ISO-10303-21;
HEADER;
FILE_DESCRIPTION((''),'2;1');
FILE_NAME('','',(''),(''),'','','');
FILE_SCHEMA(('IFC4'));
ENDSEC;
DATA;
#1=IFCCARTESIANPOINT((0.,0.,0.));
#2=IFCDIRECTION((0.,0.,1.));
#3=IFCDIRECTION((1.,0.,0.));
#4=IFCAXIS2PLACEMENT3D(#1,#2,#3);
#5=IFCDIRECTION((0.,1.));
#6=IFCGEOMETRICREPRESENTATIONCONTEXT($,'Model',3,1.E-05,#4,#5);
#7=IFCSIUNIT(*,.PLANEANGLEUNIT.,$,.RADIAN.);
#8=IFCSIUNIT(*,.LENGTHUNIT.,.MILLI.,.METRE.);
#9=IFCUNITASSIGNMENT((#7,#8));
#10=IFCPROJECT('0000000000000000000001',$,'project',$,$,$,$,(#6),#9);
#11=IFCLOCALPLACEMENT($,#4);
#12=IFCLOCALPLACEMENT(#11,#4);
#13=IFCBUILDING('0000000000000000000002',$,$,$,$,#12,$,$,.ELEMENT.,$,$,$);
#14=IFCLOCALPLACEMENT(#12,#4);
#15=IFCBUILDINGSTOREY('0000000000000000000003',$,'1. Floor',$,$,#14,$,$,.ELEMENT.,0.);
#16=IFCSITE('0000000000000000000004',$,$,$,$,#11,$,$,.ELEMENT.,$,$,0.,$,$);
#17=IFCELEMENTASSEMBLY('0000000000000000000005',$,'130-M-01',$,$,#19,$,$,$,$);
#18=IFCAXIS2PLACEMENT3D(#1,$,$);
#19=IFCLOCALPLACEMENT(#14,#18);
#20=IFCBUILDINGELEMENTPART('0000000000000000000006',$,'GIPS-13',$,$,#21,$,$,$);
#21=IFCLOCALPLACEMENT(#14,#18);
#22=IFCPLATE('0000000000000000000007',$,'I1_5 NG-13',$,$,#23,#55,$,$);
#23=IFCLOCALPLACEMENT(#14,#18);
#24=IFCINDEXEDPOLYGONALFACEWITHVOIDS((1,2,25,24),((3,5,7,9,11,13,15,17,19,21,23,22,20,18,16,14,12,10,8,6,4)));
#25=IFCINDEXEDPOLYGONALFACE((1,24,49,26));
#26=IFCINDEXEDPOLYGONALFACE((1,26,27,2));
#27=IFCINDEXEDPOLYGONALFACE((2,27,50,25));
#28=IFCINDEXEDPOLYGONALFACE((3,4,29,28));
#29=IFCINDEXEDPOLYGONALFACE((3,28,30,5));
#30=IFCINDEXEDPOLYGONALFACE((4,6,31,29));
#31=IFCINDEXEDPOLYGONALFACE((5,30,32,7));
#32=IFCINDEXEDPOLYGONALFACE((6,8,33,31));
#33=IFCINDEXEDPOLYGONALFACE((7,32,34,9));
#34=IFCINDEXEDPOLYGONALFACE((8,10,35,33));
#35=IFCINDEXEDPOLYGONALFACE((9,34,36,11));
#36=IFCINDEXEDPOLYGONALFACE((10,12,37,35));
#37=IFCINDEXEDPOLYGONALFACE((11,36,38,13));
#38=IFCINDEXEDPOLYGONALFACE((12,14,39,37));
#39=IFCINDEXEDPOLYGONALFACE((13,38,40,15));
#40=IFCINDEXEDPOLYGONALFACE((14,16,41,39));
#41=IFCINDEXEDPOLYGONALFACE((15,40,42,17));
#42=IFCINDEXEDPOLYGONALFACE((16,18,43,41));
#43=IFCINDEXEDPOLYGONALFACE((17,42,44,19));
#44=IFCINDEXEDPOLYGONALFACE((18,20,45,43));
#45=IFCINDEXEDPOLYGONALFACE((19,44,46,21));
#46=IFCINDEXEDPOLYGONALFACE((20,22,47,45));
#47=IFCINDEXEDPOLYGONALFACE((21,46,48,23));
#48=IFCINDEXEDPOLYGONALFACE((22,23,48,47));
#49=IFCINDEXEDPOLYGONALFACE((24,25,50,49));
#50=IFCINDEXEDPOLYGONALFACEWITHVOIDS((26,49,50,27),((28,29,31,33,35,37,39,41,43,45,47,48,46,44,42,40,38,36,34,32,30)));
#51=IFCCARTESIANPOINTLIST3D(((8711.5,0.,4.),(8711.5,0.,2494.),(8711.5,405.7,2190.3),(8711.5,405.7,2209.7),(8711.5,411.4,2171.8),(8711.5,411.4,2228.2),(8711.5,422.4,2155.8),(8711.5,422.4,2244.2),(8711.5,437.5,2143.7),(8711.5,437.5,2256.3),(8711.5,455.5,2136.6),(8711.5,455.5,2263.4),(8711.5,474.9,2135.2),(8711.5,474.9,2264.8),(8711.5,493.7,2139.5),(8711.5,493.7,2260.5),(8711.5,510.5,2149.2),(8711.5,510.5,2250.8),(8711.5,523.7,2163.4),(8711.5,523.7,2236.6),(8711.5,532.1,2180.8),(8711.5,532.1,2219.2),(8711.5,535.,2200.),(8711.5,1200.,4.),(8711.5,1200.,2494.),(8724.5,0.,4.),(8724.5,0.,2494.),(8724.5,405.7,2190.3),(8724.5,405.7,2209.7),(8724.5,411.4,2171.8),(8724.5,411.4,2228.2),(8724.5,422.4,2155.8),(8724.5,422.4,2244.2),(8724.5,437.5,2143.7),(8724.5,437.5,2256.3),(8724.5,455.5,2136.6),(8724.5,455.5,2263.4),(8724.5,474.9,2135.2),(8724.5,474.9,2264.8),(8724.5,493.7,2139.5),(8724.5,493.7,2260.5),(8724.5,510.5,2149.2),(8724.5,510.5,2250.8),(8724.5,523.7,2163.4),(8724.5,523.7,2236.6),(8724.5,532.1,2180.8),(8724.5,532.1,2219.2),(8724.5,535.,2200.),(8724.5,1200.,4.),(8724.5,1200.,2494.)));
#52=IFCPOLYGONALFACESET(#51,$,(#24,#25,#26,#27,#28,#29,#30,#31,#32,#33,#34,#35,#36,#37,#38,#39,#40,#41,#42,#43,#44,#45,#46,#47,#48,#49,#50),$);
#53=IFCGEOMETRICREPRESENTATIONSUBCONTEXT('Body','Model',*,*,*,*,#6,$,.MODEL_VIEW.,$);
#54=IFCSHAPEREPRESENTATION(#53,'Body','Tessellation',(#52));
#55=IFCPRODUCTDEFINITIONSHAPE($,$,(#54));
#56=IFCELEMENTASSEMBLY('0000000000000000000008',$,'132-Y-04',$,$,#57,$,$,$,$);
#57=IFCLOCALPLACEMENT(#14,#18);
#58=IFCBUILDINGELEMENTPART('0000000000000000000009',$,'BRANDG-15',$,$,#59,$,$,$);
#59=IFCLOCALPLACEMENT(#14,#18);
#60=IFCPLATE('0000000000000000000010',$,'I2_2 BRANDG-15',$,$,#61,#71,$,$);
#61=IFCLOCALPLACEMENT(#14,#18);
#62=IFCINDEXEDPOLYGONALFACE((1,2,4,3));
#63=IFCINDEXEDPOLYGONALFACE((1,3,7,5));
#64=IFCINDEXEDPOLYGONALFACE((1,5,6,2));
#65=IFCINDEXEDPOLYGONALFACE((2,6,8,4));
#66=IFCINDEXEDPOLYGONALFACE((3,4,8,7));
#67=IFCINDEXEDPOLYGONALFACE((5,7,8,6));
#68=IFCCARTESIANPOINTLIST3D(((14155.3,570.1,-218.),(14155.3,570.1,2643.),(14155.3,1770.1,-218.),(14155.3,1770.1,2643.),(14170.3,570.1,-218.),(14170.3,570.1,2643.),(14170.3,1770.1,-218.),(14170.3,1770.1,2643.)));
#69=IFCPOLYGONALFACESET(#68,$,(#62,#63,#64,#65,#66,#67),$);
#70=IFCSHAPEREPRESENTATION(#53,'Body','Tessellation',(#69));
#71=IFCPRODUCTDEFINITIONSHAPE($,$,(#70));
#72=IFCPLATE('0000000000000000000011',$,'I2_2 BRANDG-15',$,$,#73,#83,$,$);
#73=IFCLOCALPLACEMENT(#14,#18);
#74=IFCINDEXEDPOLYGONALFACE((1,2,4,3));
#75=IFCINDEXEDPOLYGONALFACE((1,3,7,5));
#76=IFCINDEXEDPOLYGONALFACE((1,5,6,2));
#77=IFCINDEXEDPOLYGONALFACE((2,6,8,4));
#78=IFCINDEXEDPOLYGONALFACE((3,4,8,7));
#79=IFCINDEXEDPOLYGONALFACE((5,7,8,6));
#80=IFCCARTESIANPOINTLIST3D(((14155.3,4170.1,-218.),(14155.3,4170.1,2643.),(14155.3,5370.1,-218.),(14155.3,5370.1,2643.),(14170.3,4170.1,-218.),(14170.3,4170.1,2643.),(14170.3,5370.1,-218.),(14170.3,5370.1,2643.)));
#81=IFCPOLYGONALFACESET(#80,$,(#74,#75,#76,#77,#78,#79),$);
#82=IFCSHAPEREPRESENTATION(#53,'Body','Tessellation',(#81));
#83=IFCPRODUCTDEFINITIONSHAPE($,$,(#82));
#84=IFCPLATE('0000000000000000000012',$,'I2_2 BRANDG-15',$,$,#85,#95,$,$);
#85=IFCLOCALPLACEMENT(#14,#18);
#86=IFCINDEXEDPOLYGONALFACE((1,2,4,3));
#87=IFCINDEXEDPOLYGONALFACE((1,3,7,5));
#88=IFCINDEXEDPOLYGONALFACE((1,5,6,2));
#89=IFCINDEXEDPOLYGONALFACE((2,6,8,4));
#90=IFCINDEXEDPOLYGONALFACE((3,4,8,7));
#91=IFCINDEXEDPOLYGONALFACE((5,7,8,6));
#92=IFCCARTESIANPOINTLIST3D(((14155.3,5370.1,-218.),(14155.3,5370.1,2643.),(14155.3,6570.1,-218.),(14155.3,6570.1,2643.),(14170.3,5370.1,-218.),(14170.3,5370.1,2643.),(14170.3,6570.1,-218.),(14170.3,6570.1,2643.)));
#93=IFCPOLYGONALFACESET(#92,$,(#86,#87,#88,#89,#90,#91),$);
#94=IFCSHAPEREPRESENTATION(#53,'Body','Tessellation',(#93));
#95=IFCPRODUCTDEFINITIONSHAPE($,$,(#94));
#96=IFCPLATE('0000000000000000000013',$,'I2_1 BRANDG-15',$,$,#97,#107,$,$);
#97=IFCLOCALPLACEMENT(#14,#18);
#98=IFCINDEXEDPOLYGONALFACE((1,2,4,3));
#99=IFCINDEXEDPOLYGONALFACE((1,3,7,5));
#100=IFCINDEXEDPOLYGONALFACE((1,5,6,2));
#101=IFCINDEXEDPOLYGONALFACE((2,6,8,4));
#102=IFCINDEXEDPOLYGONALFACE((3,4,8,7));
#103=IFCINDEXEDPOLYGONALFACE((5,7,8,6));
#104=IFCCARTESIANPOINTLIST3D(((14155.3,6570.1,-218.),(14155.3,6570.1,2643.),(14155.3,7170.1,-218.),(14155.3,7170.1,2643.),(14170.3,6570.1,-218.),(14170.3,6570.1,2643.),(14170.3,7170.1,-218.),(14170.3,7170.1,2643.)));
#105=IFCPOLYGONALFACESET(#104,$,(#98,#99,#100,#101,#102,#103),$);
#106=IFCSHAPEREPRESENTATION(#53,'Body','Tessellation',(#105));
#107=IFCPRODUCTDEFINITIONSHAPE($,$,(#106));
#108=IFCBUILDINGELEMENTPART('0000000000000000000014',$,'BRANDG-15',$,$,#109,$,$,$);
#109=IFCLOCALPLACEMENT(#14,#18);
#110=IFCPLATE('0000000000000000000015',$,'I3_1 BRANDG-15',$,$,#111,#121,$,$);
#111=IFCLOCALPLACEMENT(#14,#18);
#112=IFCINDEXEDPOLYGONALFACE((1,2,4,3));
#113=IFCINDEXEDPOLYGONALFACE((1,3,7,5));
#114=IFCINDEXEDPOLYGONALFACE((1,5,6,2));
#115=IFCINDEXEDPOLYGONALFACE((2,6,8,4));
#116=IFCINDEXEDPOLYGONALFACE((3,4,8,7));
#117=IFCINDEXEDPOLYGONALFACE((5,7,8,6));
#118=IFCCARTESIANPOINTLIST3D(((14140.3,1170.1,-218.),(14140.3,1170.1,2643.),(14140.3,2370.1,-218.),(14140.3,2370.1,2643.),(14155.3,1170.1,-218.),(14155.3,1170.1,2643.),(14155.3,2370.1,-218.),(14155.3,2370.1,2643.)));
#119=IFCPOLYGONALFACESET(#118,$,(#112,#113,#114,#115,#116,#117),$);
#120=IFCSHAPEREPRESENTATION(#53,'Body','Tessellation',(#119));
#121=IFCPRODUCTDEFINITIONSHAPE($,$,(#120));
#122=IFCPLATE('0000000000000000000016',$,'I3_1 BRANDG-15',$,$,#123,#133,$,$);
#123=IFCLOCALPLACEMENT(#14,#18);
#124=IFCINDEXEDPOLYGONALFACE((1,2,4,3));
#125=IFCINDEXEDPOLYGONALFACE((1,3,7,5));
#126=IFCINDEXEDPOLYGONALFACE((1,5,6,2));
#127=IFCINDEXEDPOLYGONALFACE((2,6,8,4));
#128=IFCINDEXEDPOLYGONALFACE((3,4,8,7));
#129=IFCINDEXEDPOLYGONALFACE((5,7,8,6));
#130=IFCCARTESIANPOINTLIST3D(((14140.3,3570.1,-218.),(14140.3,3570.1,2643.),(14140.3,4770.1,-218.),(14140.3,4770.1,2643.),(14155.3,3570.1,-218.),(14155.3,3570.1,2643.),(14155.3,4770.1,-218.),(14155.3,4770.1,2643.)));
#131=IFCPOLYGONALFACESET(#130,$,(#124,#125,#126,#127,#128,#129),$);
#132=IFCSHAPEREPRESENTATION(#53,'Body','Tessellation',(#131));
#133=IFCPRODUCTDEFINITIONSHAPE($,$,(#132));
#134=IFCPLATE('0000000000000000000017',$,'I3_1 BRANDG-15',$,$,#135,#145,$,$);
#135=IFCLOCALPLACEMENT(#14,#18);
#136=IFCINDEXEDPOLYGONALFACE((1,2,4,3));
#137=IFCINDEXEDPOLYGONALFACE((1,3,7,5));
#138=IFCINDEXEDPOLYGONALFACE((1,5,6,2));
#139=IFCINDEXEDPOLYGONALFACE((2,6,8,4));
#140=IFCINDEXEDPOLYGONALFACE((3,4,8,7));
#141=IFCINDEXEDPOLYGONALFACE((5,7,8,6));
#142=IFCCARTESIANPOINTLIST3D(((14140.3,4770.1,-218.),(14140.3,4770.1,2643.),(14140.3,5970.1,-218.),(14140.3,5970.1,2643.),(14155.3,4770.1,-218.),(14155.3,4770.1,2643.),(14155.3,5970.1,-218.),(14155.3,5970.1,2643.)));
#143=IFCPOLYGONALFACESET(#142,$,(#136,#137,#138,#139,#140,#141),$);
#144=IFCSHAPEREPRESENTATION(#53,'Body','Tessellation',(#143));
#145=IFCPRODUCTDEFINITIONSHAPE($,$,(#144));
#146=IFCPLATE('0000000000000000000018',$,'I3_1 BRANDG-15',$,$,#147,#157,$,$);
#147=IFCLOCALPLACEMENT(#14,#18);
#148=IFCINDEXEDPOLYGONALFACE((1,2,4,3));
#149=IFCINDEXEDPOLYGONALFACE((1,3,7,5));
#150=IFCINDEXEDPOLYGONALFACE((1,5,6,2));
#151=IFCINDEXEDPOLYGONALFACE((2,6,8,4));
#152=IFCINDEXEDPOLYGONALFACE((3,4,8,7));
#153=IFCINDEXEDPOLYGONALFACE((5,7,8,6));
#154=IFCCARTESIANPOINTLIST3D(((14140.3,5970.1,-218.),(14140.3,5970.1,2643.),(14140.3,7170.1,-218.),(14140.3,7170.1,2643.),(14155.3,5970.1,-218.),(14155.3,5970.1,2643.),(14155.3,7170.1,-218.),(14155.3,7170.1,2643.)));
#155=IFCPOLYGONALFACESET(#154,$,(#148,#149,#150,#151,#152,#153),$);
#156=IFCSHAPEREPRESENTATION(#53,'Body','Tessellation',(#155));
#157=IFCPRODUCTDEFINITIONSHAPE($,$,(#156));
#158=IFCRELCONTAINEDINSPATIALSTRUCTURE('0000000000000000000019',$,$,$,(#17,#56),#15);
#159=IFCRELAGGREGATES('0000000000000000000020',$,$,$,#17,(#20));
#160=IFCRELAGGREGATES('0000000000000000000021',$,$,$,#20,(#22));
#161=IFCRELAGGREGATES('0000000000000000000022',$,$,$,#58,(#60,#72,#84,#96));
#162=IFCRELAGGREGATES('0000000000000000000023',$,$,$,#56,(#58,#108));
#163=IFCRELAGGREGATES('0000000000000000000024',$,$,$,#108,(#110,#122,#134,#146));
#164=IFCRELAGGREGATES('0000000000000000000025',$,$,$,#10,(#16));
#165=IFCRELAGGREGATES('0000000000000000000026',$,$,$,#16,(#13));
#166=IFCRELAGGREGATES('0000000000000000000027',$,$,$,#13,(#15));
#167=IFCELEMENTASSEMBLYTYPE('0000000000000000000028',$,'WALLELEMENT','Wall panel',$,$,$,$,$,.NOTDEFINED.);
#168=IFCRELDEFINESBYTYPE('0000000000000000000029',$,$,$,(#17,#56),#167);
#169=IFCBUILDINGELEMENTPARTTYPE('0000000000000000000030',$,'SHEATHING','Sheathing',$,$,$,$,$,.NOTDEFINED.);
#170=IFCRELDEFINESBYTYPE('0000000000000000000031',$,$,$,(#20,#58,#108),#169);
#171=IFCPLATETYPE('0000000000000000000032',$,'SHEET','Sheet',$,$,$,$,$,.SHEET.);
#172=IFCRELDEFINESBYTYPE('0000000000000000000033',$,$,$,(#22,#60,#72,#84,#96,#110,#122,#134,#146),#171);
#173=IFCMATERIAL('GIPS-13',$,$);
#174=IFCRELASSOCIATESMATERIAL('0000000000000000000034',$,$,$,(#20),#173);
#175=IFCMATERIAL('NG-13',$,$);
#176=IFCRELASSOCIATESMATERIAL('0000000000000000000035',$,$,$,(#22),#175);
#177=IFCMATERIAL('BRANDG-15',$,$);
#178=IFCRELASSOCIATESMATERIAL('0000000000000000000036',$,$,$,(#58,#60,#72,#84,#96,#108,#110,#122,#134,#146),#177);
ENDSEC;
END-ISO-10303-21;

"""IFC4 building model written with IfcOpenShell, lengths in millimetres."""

from ifc_helpers import new_model, si_unit, direction, frame, origin_with_axes, origin_2d_with_axis, place, context, subcontext, project, spatial, rectangle, circle, extrude, boolean, material, type_object, element, aggregate, save


model = new_model("IFC4")

# Units and contexts
model_context = context("Model", 3, precision=1e-05, world=origin_with_axes(), true_north=direction((0.0, 1.0)))
body_context = subcontext(model_context, "Body", "Model", "MODEL_VIEW")
ifc_project = project(units=[si_unit("PLANEANGLEUNIT", "RADIAN"), si_unit("LENGTHUNIT", "METRE", prefix="MILLI")], contexts=[model_context])

# Site, building, storey
site_placement = place(None, origin_with_axes())
site = spatial("IfcSite", under=ifc_project, at=site_placement, CompositionType="ELEMENT", RefElevation=0.0)
building_placement = place(site_placement, origin_with_axes())
building = spatial("IfcBuilding", under=site, at=building_placement, CompositionType="ELEMENT")
storey_placement = place(building_placement, origin_with_axes())
storey = spatial("IfcBuildingStorey", under=building, at=storey_placement, Name="1. Floor", CompositionType="ELEMENT", Elevation=0.0)

# Shared definitions
element_assembly_type = type_object("IfcElementAssemblyType", Name="WALLELEMENT", Description="Wall panel", PredefinedType="NOTDEFINED")
ifc_material_1 = material(Name="BRANDG-15")
building_element_part_type_1 = type_object("IfcBuildingElementPartType", Name="SHEATHING", Description="Sheathing", PredefinedType="NOTDEFINED")
plate_type = type_object("IfcPlateType", Name="SHEET", Description="Sheet", PredefinedType="SHEET")

# Element assemblies, building element parts, plates
assembly_1_placement = place(storey_placement, origin_with_axes())
assembly_1 = element("IfcElementAssembly", 1, at=assembly_1_placement, inside=storey, type_object=element_assembly_type, Name="130-M-01")
ifc_material_2 = material(Name="GIPS-13")
ifc_material_3 = material(Name="NG-13")
building_element_part_1_placement = place(storey_placement, origin_with_axes())
building_element_part_1 = element("IfcBuildingElementPart", 2, at=building_element_part_1_placement, type_object=building_element_part_type_1, material=ifc_material_2, Name="GIPS-13")
aggregate(assembly_1, [building_element_part_1])
plate_1_placement = place(storey_placement, frame((8724.5, 600.0, 5004.0), z_axis=(1.0, 0.0, 0.0), x_axis=(0.0, 1.0, 0.0)))
plate_1 = element("IfcPlate", 3, at=plate_1_placement, type_object=plate_type, material=ifc_material_3, Name="I1_5 NG-13", context=body_context, shape_type="CSG", body=[
    boolean("DIFFERENCE", extrude(rectangle(XDim=13.0, YDim=1200.0, at=origin_2d_with_axis()), frame((0.0, -5000.0, -6.5), z_axis=(0.0, 1.0, 0.0), x_axis=(0.0, 0.0, 1.0)), (0.0, 0.0, 1.0), 2490.0), extrude(circle(Radius=65.0, at=origin_2d_with_axis()), frame((-130.0, -2804.0, -27.0), z_axis=(0.0, 0.0, -1.0), x_axis=(1.0, 0.0, 0.0)), (0.0, 0.0, -1.0), 63.0)),
])
aggregate(building_element_part_1, [plate_1])
assembly_2_placement = place(storey_placement, origin_with_axes())
assembly_2 = element("IfcElementAssembly", 4, at=assembly_2_placement, inside=storey, type_object=element_assembly_type, Name="132-Y-04")
building_element_part_2_placement = place(storey_placement, origin_with_axes())
building_element_part_2 = element("IfcBuildingElementPart", 5, at=building_element_part_2_placement, type_object=building_element_part_type_1, material=ifc_material_1, Name="BRANDG-15")
plate_2_placement = place(storey_placement, frame((14170.3, 1170.1, 4782.0), z_axis=(1.0, 0.0, 0.0), x_axis=(0.0, 1.0, 0.0)))
plate_2 = element("IfcPlate", 6, at=plate_2_placement, type_object=plate_type, material=ifc_material_1, Name="I2_2 BRANDG-15", context=body_context, shape_type="SweptSolid", body=[
    extrude(rectangle(XDim=15.0, YDim=1200.0, at=origin_2d_with_axis()), frame((0.0, -5000.0, -7.5), z_axis=(0.0, 1.0, 0.0), x_axis=(0.0, 0.0, 1.0)), (0.0, 0.0, 1.0), 2861.0),
])
plate_3_placement = place(storey_placement, frame((14170.3, 4770.1, 4782.0), z_axis=(1.0, 0.0, 0.0), x_axis=(0.0, 1.0, 0.0)))
plate_3 = element("IfcPlate", 7, at=plate_3_placement, type_object=plate_type, material=ifc_material_1, Name="I2_2 BRANDG-15", context=body_context, shape_type="SweptSolid", body=[
    extrude(rectangle(XDim=15.0, YDim=1200.0, at=origin_2d_with_axis()), frame((0.0, -5000.0, -7.5), z_axis=(0.0, 1.0, 0.0), x_axis=(0.0, 0.0, 1.0)), (0.0, 0.0, 1.0), 2861.0),
])
plate_4_placement = place(storey_placement, frame((14170.3, 5970.1, 4782.0), z_axis=(1.0, 0.0, 0.0), x_axis=(0.0, 1.0, 0.0)))
plate_4 = element("IfcPlate", 8, at=plate_4_placement, type_object=plate_type, material=ifc_material_1, Name="I2_2 BRANDG-15", context=body_context, shape_type="SweptSolid", body=[
    extrude(rectangle(XDim=15.0, YDim=1200.0, at=origin_2d_with_axis()), frame((0.0, -5000.0, -7.5), z_axis=(0.0, 1.0, 0.0), x_axis=(0.0, 0.0, 1.0)), (0.0, 0.0, 1.0), 2861.0),
])
plate_5_placement = place(storey_placement, frame((14170.3, 6570.1, 4782.0), z_axis=(1.0, 0.0, 0.0), x_axis=(0.0, 1.0, 0.0)))
plate_5 = element("IfcPlate", 9, at=plate_5_placement, type_object=plate_type, material=ifc_material_1, Name="I2_1 BRANDG-15", context=body_context, shape_type="SweptSolid", body=[
    extrude(rectangle(XDim=15.0, YDim=600.0, at=origin_2d_with_axis()), frame((300.0, -5000.0, -7.5), z_axis=(0.0, 1.0, 0.0), x_axis=(0.0, 0.0, 1.0)), (0.0, 0.0, 1.0), 2861.0),
])
aggregate(building_element_part_2, [plate_2, plate_3, plate_4, plate_5])
building_element_part_3_placement = place(storey_placement, origin_with_axes())
building_element_part_3 = element("IfcBuildingElementPart", 10, at=building_element_part_3_placement, type_object=building_element_part_type_1, material=ifc_material_1, Name="BRANDG-15")
aggregate(assembly_2, [building_element_part_2, building_element_part_3])
plate_6_placement = place(storey_placement, frame((14155.3, 1770.1, 4782.0), z_axis=(1.0, 0.0, 0.0), x_axis=(0.0, 1.0, 0.0)))
plate_6 = element("IfcPlate", 11, at=plate_6_placement, type_object=plate_type, material=ifc_material_1, Name="I3_1 BRANDG-15", context=body_context, shape_type="SweptSolid", body=[
    extrude(rectangle(XDim=15.0, YDim=1200.0, at=origin_2d_with_axis()), frame((0.0, -5000.0, -7.5), z_axis=(0.0, 1.0, 0.0), x_axis=(0.0, 0.0, 1.0)), (0.0, 0.0, 1.0), 2861.0),
])
plate_7_placement = place(storey_placement, frame((14155.3, 4170.1, 4782.0), z_axis=(1.0, 0.0, 0.0), x_axis=(0.0, 1.0, 0.0)))
plate_7 = element("IfcPlate", 12, at=plate_7_placement, type_object=plate_type, material=ifc_material_1, Name="I3_1 BRANDG-15", context=body_context, shape_type="SweptSolid", body=[
    extrude(rectangle(XDim=15.0, YDim=1200.0, at=origin_2d_with_axis()), frame((0.0, -5000.0, -7.5), z_axis=(0.0, 1.0, 0.0), x_axis=(0.0, 0.0, 1.0)), (0.0, 0.0, 1.0), 2861.0),
])
plate_8_placement = place(storey_placement, frame((14155.3, 5370.1, 4782.0), z_axis=(1.0, 0.0, 0.0), x_axis=(0.0, 1.0, 0.0)))
plate_8 = element("IfcPlate", 13, at=plate_8_placement, type_object=plate_type, material=ifc_material_1, Name="I3_1 BRANDG-15", context=body_context, shape_type="SweptSolid", body=[
    extrude(rectangle(XDim=15.0, YDim=1200.0, at=origin_2d_with_axis()), frame((0.0, -5000.0, -7.5), z_axis=(0.0, 1.0, 0.0), x_axis=(0.0, 0.0, 1.0)), (0.0, 0.0, 1.0), 2861.0),
])
plate_9_placement = place(storey_placement, frame((14155.3, 6570.1, 4782.0), z_axis=(1.0, 0.0, 0.0), x_axis=(0.0, 1.0, 0.0)))
plate_9 = element("IfcPlate", 14, at=plate_9_placement, type_object=plate_type, material=ifc_material_1, Name="I3_1 BRANDG-15", context=body_context, shape_type="SweptSolid", body=[
    extrude(rectangle(XDim=15.0, YDim=1200.0, at=origin_2d_with_axis()), frame((0.0, -5000.0, -7.5), z_axis=(0.0, 1.0, 0.0), x_axis=(0.0, 0.0, 1.0)), (0.0, 0.0, 1.0), 2861.0),
])
aggregate(building_element_part_3, [plate_6, plate_7, plate_8, plate_9])

save(model, "model.ifc")
